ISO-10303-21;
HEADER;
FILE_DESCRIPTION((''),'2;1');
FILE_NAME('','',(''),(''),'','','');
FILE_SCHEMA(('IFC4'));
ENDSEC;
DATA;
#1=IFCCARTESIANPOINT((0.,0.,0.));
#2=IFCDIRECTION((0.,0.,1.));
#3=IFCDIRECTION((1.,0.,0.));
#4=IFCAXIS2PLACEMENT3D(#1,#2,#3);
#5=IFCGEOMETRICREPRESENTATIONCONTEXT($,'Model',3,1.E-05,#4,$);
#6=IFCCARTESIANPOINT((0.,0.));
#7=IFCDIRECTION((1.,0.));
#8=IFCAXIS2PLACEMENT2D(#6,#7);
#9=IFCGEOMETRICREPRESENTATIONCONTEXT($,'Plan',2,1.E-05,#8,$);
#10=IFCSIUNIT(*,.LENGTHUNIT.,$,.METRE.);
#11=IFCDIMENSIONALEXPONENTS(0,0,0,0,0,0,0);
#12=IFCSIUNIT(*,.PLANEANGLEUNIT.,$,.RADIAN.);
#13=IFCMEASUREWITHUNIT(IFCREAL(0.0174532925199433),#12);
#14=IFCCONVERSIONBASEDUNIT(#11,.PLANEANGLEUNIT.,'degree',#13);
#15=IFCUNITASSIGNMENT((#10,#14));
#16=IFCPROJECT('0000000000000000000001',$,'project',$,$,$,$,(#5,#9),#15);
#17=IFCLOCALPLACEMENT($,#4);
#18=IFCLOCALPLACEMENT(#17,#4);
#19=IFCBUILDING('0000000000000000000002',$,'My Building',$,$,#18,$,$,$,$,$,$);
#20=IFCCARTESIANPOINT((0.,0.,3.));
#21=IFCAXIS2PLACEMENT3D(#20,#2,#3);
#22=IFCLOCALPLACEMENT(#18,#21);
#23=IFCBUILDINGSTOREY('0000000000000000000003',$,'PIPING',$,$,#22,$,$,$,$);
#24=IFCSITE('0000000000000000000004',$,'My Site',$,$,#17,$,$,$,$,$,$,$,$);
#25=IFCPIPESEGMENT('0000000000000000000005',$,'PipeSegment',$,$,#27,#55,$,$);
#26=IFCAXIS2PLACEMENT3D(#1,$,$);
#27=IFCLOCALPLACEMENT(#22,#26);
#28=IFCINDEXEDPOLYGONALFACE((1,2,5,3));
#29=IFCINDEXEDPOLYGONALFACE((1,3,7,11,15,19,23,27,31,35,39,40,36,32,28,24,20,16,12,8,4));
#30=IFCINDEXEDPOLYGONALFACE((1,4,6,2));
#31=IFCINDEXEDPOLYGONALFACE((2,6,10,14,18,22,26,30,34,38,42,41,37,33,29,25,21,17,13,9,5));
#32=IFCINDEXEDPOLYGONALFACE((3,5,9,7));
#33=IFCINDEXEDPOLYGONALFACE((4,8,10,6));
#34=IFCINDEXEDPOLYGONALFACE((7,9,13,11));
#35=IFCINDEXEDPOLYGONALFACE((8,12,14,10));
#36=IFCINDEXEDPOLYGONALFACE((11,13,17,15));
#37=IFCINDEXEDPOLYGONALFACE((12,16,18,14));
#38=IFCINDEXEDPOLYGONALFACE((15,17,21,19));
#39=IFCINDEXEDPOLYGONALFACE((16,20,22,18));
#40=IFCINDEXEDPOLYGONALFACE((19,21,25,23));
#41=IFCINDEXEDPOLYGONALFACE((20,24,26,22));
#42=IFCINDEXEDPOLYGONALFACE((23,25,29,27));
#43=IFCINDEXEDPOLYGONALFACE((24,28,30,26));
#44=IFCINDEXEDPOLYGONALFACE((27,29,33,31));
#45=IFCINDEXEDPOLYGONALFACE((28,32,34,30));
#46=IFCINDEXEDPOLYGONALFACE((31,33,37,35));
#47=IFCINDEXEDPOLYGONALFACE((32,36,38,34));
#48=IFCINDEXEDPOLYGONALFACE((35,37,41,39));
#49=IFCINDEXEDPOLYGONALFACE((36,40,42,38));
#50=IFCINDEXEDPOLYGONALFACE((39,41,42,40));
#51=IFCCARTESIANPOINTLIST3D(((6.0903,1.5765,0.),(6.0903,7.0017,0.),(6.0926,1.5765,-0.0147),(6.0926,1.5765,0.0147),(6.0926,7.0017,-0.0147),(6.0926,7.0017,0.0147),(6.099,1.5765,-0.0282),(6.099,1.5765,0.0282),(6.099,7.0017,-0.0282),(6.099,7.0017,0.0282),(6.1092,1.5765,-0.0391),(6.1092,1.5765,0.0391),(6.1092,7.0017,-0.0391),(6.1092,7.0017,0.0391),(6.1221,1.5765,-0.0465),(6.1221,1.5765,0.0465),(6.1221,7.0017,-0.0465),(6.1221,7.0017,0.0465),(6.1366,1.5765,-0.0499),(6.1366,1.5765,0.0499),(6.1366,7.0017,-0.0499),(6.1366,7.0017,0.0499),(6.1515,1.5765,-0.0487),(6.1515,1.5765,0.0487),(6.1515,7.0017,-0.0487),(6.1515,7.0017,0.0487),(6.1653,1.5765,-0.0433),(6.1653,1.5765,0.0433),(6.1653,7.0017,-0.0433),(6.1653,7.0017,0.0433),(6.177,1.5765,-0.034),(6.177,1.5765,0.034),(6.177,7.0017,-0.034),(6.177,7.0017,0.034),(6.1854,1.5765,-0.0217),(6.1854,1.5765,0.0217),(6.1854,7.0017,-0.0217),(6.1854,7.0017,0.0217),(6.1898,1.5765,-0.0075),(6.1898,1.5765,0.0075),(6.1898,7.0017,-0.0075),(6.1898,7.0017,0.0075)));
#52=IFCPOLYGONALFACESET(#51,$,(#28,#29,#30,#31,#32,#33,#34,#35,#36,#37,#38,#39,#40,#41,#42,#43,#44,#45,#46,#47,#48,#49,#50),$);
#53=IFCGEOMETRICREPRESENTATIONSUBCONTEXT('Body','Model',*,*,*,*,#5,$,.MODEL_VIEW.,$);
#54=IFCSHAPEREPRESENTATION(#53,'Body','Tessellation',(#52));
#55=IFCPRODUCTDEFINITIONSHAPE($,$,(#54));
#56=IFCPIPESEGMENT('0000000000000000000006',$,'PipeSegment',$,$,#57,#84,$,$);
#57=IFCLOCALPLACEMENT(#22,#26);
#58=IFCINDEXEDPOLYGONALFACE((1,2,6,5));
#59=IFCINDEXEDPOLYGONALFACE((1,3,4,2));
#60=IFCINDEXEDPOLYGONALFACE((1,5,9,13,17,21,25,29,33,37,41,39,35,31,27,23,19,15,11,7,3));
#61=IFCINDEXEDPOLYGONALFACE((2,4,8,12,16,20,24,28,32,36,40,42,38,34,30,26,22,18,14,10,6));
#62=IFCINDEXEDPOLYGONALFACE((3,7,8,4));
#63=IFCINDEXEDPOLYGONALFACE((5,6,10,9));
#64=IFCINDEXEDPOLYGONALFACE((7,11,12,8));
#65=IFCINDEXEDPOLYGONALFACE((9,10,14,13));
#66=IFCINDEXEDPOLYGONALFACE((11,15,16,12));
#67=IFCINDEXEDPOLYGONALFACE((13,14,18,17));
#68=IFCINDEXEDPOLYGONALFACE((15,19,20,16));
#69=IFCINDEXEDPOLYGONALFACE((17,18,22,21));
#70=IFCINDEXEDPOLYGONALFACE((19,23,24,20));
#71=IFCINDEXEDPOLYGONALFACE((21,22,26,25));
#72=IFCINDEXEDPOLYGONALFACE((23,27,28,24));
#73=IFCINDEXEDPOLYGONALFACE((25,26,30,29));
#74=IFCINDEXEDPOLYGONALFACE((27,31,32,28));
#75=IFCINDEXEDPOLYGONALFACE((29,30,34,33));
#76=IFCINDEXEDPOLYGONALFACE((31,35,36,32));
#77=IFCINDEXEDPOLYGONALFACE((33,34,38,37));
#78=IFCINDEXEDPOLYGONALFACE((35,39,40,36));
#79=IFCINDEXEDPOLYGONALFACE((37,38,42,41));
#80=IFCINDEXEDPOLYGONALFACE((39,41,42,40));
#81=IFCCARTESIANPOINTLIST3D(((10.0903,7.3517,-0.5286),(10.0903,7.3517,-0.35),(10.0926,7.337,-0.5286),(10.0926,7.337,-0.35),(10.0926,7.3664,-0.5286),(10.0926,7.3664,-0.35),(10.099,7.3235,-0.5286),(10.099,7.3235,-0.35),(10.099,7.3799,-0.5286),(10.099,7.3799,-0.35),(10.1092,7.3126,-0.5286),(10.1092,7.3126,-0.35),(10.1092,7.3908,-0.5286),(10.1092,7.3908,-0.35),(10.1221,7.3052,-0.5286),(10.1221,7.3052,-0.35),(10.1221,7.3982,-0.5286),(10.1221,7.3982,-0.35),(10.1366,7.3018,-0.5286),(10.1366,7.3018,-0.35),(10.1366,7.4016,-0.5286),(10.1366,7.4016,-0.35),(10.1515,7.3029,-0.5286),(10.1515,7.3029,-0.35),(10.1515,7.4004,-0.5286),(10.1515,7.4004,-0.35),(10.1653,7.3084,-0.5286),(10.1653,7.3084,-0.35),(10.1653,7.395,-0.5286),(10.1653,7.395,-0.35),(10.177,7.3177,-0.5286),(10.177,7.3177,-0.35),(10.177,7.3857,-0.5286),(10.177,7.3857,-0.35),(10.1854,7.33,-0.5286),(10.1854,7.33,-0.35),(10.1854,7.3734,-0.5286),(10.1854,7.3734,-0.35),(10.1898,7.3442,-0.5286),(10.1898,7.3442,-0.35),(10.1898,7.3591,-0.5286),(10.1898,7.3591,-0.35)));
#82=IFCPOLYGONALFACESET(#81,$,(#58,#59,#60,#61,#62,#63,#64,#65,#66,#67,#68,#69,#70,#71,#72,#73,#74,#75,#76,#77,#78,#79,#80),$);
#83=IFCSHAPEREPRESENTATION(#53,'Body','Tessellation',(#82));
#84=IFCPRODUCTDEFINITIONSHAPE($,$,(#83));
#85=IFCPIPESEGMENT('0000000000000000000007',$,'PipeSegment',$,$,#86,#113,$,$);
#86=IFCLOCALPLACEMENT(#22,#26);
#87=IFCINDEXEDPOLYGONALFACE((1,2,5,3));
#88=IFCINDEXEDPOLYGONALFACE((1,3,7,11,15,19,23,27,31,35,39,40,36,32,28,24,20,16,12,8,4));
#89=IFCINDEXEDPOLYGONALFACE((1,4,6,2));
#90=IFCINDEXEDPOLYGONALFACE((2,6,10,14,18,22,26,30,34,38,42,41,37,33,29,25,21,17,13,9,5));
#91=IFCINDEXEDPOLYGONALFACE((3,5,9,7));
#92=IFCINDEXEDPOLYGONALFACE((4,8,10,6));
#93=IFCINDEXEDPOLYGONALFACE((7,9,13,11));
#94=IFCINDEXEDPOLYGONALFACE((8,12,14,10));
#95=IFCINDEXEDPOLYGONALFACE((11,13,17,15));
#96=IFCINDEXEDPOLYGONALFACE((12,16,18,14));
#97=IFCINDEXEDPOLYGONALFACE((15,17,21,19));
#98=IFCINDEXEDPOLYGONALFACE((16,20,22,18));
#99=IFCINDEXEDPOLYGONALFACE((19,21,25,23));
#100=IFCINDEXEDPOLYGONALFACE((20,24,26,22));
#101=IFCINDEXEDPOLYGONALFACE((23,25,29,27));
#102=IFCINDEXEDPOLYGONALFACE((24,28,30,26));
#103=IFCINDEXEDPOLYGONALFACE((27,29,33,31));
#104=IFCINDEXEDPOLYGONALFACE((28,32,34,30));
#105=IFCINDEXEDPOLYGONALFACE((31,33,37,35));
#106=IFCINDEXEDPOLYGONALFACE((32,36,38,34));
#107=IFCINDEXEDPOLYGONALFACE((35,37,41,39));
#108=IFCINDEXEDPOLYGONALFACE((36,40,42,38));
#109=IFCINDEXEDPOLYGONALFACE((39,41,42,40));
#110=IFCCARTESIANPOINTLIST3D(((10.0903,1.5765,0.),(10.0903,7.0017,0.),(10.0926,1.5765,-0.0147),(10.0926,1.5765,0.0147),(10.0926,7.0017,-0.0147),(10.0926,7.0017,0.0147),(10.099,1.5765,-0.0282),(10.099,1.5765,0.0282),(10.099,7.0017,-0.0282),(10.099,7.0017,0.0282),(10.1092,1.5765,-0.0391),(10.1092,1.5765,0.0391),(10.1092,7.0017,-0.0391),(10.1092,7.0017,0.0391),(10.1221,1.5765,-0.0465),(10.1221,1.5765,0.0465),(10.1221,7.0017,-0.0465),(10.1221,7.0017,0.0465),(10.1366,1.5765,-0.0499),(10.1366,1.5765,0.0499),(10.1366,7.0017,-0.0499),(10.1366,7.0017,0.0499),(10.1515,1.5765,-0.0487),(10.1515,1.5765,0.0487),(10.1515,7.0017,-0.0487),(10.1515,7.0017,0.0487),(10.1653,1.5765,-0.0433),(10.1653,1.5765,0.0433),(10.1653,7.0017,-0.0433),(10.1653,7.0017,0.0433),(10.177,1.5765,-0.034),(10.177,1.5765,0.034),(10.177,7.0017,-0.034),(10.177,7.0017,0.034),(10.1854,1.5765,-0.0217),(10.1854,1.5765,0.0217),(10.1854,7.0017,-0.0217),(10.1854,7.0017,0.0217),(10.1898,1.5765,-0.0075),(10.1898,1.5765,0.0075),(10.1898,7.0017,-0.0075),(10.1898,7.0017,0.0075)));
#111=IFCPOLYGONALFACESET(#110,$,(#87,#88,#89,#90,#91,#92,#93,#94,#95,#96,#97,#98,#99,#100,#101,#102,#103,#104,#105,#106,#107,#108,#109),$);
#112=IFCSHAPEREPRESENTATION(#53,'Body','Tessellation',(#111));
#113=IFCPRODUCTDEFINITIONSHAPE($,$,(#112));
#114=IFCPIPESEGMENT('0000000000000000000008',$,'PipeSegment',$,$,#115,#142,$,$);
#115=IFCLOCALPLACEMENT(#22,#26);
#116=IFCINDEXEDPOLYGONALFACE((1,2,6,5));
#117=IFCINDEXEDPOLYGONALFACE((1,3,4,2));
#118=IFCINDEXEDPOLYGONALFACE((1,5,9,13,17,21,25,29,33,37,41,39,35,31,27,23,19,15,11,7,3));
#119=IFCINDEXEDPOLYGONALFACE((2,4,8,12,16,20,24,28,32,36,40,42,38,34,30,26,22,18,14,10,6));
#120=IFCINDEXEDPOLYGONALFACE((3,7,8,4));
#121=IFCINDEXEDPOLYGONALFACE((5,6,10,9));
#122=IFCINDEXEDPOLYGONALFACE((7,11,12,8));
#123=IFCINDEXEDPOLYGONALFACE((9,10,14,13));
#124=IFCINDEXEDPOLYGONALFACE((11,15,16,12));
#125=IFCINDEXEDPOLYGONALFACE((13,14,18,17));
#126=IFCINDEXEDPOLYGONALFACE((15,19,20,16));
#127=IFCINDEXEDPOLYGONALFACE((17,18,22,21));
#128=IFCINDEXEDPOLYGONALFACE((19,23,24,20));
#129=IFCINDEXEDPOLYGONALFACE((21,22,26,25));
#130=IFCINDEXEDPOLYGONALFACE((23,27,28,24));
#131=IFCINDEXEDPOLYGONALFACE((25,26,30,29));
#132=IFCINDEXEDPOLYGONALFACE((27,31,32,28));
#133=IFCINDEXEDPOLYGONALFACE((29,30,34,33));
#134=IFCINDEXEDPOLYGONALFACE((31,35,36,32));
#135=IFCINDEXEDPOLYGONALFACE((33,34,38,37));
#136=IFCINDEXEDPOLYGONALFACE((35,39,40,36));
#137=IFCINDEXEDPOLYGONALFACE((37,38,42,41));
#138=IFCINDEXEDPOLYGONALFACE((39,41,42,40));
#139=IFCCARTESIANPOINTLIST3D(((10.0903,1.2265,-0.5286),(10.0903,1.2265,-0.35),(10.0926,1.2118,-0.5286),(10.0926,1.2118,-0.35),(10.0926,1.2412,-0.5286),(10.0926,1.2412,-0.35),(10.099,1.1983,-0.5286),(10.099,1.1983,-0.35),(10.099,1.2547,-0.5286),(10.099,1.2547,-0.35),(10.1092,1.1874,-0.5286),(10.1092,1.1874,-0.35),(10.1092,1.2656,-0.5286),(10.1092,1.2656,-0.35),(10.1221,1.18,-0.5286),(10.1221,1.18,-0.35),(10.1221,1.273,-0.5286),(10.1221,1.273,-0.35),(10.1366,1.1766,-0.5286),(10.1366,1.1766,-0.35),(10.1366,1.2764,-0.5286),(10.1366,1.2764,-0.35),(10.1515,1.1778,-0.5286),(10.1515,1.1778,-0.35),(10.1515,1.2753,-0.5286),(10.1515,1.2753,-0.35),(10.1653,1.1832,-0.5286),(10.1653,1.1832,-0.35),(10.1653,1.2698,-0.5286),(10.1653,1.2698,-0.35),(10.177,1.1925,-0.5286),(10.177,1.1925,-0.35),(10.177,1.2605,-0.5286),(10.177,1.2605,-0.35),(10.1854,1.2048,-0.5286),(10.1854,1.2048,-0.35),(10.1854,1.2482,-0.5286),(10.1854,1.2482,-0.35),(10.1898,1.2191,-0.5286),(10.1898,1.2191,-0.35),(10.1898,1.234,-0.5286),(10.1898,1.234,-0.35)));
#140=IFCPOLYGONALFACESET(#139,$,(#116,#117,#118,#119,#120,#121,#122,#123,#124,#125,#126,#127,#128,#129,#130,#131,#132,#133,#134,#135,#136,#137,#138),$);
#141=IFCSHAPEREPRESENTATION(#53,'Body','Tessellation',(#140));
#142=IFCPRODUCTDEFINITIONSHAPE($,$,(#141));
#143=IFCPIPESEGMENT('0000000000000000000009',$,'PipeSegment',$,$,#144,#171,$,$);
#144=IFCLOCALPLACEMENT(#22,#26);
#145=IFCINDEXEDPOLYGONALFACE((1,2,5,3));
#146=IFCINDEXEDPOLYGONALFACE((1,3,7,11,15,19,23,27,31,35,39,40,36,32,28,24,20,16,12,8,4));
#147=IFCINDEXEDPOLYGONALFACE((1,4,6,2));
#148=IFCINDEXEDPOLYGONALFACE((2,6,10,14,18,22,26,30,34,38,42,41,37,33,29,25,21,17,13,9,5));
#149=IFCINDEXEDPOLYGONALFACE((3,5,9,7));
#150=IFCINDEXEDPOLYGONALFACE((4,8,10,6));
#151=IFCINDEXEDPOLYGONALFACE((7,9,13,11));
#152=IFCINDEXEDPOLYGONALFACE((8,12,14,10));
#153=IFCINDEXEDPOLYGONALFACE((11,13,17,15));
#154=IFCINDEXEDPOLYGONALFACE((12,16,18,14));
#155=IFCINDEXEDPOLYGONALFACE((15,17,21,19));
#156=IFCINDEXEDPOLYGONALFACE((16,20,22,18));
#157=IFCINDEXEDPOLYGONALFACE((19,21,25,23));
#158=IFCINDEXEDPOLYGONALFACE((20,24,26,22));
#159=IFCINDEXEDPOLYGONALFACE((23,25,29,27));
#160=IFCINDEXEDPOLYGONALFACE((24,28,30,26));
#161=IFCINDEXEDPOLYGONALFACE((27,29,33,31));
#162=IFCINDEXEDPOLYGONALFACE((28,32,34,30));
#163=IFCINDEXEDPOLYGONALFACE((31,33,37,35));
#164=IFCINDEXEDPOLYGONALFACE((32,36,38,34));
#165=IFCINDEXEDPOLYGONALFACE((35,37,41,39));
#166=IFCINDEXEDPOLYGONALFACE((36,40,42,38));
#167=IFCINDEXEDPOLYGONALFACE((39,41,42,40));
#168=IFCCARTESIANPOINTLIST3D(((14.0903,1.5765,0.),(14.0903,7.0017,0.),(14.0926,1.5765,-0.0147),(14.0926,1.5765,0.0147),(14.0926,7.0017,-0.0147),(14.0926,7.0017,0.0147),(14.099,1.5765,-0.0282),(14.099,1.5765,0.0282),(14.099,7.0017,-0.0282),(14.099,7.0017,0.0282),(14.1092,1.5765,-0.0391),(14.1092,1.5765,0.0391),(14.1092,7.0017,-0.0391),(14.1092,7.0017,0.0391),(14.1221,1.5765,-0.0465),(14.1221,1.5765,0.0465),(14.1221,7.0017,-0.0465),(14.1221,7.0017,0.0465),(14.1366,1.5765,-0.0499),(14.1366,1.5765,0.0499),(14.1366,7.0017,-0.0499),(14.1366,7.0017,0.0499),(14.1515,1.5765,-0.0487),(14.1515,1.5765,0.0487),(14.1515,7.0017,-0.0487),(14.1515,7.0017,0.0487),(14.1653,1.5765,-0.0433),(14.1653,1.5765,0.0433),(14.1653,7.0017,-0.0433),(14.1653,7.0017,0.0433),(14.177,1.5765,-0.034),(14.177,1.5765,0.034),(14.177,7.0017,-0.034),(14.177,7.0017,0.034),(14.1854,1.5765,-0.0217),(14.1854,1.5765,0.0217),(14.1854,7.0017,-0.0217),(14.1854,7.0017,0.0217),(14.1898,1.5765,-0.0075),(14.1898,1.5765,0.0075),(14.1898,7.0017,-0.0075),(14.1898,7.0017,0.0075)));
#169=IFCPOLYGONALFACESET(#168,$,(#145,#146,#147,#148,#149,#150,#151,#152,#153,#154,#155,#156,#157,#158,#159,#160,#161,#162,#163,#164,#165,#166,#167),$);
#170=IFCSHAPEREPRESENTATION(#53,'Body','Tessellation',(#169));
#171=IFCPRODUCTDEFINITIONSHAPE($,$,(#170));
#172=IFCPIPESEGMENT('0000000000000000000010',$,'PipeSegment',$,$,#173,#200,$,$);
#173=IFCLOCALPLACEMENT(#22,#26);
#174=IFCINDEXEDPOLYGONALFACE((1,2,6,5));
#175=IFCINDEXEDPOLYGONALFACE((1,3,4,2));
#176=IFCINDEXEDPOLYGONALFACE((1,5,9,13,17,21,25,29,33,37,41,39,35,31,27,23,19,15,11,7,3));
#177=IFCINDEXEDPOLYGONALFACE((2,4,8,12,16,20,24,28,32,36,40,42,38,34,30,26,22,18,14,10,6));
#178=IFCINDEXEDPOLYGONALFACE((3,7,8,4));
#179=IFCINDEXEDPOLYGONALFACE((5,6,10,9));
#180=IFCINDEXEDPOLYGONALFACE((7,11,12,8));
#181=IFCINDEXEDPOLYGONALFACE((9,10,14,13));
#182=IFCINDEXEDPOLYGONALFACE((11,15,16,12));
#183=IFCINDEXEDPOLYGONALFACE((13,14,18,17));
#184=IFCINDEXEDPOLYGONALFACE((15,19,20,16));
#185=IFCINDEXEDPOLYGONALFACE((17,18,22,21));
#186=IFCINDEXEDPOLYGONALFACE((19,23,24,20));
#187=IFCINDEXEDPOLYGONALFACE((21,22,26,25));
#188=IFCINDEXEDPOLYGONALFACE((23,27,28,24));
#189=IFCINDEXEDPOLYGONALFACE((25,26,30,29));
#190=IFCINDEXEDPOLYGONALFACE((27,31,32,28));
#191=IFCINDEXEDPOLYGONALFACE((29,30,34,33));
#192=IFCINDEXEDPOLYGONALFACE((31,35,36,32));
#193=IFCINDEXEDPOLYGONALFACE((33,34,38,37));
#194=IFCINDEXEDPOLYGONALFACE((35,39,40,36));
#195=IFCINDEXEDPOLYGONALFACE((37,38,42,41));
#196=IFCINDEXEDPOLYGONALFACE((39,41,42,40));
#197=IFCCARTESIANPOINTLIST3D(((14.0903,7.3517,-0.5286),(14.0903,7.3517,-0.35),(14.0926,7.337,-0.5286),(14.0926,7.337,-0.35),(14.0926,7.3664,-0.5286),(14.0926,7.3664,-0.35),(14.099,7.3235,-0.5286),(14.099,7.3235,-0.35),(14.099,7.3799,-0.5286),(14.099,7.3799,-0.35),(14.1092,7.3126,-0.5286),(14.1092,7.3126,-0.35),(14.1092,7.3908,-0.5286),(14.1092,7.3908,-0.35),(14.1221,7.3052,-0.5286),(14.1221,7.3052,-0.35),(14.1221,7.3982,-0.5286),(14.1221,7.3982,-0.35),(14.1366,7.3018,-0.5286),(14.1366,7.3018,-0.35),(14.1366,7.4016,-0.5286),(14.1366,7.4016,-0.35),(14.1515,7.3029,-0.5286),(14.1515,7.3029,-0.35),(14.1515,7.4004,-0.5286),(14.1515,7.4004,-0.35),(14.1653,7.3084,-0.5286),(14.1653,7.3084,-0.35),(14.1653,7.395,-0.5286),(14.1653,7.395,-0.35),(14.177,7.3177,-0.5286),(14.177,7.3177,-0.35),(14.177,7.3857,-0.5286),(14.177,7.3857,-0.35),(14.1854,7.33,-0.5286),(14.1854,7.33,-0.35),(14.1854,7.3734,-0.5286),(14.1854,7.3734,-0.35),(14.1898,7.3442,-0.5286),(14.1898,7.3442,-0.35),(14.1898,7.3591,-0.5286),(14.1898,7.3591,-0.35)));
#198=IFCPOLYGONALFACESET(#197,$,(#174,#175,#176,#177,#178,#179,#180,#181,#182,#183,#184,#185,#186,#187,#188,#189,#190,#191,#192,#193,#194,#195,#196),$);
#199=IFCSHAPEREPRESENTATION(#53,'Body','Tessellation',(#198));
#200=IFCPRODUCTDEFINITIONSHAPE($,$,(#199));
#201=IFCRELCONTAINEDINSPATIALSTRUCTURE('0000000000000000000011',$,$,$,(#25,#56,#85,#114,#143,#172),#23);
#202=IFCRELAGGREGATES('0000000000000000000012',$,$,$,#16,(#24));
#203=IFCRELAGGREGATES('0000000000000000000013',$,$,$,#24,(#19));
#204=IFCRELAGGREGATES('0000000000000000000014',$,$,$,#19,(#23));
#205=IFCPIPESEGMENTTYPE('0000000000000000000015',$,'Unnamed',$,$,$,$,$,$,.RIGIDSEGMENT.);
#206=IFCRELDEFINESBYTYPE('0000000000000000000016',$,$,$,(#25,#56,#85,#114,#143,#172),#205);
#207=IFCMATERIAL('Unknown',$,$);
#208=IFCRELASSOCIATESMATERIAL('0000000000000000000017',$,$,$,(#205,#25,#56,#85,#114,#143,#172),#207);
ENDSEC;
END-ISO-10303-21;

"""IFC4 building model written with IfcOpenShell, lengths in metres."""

from ifc_helpers import new_model, entity, si_unit, converted_unit, frame, origin_with_axes, origin_2d_with_axis, place, context, subcontext, project, spatial, circle, extrude, material, material_profile, profile_set, profile_usage, type_object, element, save


model = new_model("IFC4")

# Units and contexts
model_context = context("Model", 3, precision=1e-05, world=origin_with_axes())
plan_context = context("Plan", 2, precision=1e-05, world=origin_2d_with_axis())
body_context = subcontext(model_context, "Body", "Model", "MODEL_VIEW")
ifc_project = project(units=[si_unit("LENGTHUNIT", "METRE"), converted_unit("PLANEANGLEUNIT", "degree", entity("IfcReal", 0.0174532925199433), si_unit("PLANEANGLEUNIT", "RADIAN"), dimensions=[0, 0, 0, 0, 0, 0, 0])], contexts=[model_context, plan_context])

# Site, building, storey
site_placement = place(None, origin_with_axes())
site = spatial("IfcSite", under=ifc_project, at=site_placement, Name="My Site")
building_placement = place(site_placement, origin_with_axes())
building = spatial("IfcBuilding", under=site, at=building_placement, Name="My Building")
storey_placement = place(building_placement, frame((0.0, 0.0, 3.0), z_axis=(0.0, 0.0, 1.0), x_axis=(1.0, 0.0, 0.0)))
storey = spatial("IfcBuildingStorey", under=building, at=storey_placement, Name="PIPING")

# Pipe segments
ifc_material = material(Name="Unknown")
ifc_material_profile = material_profile(ifc_material, circle(Radius=0.05))
ifc_profile_set = profile_set([ifc_material_profile])
pipe_segment_type = type_object("IfcPipeSegmentType", Name="Unnamed", PredefinedType="RIGIDSEGMENT", material=ifc_profile_set)
ifc_profile_usage_1 = profile_usage(ifc_profile_set, cardinal=5)
pipe_segment_1_placement = place(storey_placement, frame((6.1403, 1.5765, 0.0), z_axis=(0.0, 1.0, 0.0), x_axis=(-1.0, 0.0, 0.0)))
element("IfcPipeSegment", 1, at=pipe_segment_1_placement, inside=storey, type_object=pipe_segment_type, material=ifc_profile_usage_1, Name="PipeSegment", context=body_context, shape_type="SweptSolid", body=[
    extrude(circle(Radius=0.05), origin_with_axes(), (0.0, 0.0, 1.0), 5.4252),
])
ifc_profile_usage_2 = profile_usage(ifc_profile_set, cardinal=5)
pipe_segment_2_placement = place(storey_placement, frame((10.1403, 7.3517, -0.35), z_axis=(0.0, 0.0, -1.0), x_axis=(-1.0, 0.0, 0.0)))
element("IfcPipeSegment", 2, at=pipe_segment_2_placement, inside=storey, type_object=pipe_segment_type, material=ifc_profile_usage_2, Name="PipeSegment", context=body_context, shape_type="SweptSolid", body=[
    extrude(circle(Radius=0.05), origin_with_axes(), (0.0, 0.0, 1.0), 0.1786),
])
ifc_profile_usage_3 = profile_usage(ifc_profile_set, cardinal=5)
pipe_segment_3_placement = place(storey_placement, frame((10.1403, 1.5765, 0.0), z_axis=(0.0, 1.0, 0.0), x_axis=(-1.0, 0.0, 0.0)))
element("IfcPipeSegment", 3, at=pipe_segment_3_placement, inside=storey, type_object=pipe_segment_type, material=ifc_profile_usage_3, Name="PipeSegment", context=body_context, shape_type="SweptSolid", body=[
    extrude(circle(Radius=0.05), origin_with_axes(), (0.0, 0.0, 1.0), 5.4252),
])
ifc_profile_usage_4 = profile_usage(ifc_profile_set, cardinal=5)
pipe_segment_4_placement = place(storey_placement, frame((10.1403, 1.2265, -0.35), z_axis=(0.0, 0.0, -1.0), x_axis=(-1.0, 0.0, 0.0)))
element("IfcPipeSegment", 4, at=pipe_segment_4_placement, inside=storey, type_object=pipe_segment_type, material=ifc_profile_usage_4, Name="PipeSegment", context=body_context, shape_type="SweptSolid", body=[
    extrude(circle(Radius=0.05), origin_with_axes(), (0.0, 0.0, 1.0), 0.1786),
])
ifc_profile_usage_5 = profile_usage(ifc_profile_set, cardinal=5)
pipe_segment_5_placement = place(storey_placement, frame((14.1403, 1.5765, 0.0), z_axis=(0.0, 1.0, 0.0), x_axis=(-1.0, 0.0, 0.0)))
element("IfcPipeSegment", 5, at=pipe_segment_5_placement, inside=storey, type_object=pipe_segment_type, material=ifc_profile_usage_5, Name="PipeSegment", context=body_context, shape_type="SweptSolid", body=[
    extrude(circle(Radius=0.05), origin_with_axes(), (0.0, 0.0, 1.0), 5.4252),
])
ifc_profile_usage_6 = profile_usage(ifc_profile_set, cardinal=5)
pipe_segment_6_placement = place(storey_placement, frame((14.1403, 7.3517, -0.35), z_axis=(0.0, 0.0, -1.0), x_axis=(-1.0, 0.0, 0.0)))
element("IfcPipeSegment", 6, at=pipe_segment_6_placement, inside=storey, type_object=pipe_segment_type, material=ifc_profile_usage_6, Name="PipeSegment", context=body_context, shape_type="SweptSolid", body=[
    extrude(circle(Radius=0.05), origin_with_axes(), (0.0, 0.0, 1.0), 0.1786),
])

save(model, "model.ifc")
